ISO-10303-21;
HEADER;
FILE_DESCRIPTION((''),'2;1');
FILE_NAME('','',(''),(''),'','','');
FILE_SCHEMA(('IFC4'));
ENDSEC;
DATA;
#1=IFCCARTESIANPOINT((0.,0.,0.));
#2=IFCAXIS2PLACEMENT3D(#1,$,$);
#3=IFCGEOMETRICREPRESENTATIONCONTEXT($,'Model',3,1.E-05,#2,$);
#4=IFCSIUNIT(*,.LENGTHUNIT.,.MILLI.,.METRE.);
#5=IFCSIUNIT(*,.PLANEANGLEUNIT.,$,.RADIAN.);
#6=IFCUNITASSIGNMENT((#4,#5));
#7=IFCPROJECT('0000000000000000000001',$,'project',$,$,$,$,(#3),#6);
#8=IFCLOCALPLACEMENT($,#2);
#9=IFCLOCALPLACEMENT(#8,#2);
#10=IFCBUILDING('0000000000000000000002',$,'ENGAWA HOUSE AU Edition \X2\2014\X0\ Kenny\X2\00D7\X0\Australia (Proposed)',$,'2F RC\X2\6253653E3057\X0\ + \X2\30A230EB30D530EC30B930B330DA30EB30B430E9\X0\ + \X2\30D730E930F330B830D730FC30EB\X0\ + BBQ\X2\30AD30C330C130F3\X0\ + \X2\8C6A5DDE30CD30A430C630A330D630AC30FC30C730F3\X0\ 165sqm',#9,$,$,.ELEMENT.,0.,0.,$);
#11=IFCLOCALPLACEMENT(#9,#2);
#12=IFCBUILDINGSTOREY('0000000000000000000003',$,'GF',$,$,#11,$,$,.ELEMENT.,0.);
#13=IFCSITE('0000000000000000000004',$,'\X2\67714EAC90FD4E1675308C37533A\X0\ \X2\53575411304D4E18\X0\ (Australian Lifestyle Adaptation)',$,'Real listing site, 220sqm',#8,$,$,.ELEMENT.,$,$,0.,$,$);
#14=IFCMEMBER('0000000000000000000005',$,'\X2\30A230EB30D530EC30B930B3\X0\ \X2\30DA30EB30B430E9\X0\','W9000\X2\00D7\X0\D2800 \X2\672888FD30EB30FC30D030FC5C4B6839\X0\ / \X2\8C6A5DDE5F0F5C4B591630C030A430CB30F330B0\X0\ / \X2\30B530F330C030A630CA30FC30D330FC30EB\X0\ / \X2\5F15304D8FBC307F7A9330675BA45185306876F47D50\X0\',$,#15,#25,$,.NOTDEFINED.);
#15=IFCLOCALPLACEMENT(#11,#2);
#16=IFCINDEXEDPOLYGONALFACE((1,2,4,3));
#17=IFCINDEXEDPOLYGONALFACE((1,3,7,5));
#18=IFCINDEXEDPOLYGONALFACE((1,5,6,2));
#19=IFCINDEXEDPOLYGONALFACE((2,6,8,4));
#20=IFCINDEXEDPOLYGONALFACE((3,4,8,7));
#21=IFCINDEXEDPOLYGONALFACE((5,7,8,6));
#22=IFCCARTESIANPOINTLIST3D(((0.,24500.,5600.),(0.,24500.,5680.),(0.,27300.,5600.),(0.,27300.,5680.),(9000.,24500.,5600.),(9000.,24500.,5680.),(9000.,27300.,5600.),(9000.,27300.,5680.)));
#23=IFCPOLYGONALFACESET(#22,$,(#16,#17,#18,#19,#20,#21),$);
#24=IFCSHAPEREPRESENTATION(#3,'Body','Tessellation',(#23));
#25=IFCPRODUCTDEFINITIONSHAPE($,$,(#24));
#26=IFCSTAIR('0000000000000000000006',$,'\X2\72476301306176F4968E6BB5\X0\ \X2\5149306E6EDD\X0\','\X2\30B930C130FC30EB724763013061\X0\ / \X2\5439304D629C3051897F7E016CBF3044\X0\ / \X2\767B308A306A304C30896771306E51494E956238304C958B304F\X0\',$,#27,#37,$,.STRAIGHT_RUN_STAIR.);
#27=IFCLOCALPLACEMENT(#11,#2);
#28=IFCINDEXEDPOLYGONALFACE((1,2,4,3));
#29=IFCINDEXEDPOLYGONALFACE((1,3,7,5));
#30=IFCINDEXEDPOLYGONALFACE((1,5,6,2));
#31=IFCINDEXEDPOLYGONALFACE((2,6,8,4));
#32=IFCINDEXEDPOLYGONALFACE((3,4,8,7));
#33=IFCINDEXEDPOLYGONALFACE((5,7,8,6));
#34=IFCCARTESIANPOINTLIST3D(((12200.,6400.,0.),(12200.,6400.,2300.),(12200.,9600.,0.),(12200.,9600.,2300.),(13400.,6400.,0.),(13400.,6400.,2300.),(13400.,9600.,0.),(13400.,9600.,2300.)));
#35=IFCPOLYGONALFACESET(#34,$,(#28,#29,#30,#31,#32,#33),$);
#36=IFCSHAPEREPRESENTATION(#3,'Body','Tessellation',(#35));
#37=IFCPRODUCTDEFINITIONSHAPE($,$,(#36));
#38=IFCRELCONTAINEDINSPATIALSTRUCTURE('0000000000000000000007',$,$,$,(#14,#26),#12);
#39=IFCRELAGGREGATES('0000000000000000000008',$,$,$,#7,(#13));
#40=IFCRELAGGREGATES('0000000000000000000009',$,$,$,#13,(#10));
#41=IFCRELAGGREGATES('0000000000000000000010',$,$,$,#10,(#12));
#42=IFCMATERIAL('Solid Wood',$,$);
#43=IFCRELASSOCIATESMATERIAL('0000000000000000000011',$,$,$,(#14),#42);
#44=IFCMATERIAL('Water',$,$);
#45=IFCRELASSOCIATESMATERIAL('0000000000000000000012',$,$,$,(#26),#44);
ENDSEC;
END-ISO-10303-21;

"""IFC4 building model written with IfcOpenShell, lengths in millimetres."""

from ifc_helpers import new_model, si_unit, frame, frame_2d, origin, place, context, project, spatial, rectangle, extrude, material, element, save


model = new_model("IFC4")

# Units and contexts
model_context = context("Model", 3, precision=1e-05, world=origin())
ifc_project = project(units=[si_unit("LENGTHUNIT", "METRE", prefix="MILLI"), si_unit("PLANEANGLEUNIT", "RADIAN")], contexts=[model_context])

# Site, building, storey
site_placement = place(None, origin())
site = spatial("IfcSite", under=ifc_project, at=site_placement, Name="東京都世田谷区 南向き丘 (Australian Lifestyle Adaptation)", ObjectType="Real listing site, 220sqm", CompositionType="ELEMENT", RefElevation=0.0)
building_placement = place(site_placement, origin())
building = spatial("IfcBuilding", under=site, at=building_placement, Name="ENGAWA HOUSE AU Edition — Kenny×Australia (Proposed)", ObjectType="2F RC打放し + アルフレスコペルゴラ + プランジプール + BBQキッチン + 豪州ネイティブガーデン 165sqm", CompositionType="ELEMENT", ElevationOfRefHeight=0.0, ElevationOfTerrain=0.0)
storey_placement = place(building_placement, origin())
storey = spatial("IfcBuildingStorey", under=building, at=storey_placement, Name="GF", CompositionType="ELEMENT", Elevation=0.0)

# Member
ifc_material_1 = material(Name="Solid Wood")
member_1_placement = place(storey_placement, frame((0.0, 12250.0, 2800.0)))
element("IfcMember", 1, at=member_1_placement, inside=storey, material=ifc_material_1, Name="アルフレスコ ペルゴラ", Description="W9000×D2800 木製ルーバー屋根 / 豪州式屋外ダイニング / サンダウナービール / 引き込み窓で室内と直結", PredefinedType="NOTDEFINED", context=model_context, shape_type="SweptSolid", body=[
    extrude(rectangle(XDim=9000.0, YDim=2800.0, at=frame_2d((4500.0, 1400.0))), frame((0.0, 12250.0, 2800.0)), (0.0, 0.0, 1.0), 80.0),
])

# Stair
ifc_material_2 = material(Name="Water")
stair_placement = place(storey_placement, frame((6100.0, 3200.0, 0.0)))
element("IfcStair", 2, at=stair_placement, inside=storey, material=ifc_material_2, Name="片持ち直階段 光の滝", Description="スチール片持ち / 吹き抜け西縁沿い / 登りながら東の光井戸が開く", PredefinedType="STRAIGHT_RUN_STAIR", context=model_context, shape_type="SweptSolid", body=[
    extrude(rectangle(XDim=1200.0, YDim=3200.0, at=frame_2d((600.0, 1600.0))), frame((6100.0, 3200.0, 0.0)), (0.0, 0.0, 1.0), 2300.0),
])

save(model, "model.ifc")
